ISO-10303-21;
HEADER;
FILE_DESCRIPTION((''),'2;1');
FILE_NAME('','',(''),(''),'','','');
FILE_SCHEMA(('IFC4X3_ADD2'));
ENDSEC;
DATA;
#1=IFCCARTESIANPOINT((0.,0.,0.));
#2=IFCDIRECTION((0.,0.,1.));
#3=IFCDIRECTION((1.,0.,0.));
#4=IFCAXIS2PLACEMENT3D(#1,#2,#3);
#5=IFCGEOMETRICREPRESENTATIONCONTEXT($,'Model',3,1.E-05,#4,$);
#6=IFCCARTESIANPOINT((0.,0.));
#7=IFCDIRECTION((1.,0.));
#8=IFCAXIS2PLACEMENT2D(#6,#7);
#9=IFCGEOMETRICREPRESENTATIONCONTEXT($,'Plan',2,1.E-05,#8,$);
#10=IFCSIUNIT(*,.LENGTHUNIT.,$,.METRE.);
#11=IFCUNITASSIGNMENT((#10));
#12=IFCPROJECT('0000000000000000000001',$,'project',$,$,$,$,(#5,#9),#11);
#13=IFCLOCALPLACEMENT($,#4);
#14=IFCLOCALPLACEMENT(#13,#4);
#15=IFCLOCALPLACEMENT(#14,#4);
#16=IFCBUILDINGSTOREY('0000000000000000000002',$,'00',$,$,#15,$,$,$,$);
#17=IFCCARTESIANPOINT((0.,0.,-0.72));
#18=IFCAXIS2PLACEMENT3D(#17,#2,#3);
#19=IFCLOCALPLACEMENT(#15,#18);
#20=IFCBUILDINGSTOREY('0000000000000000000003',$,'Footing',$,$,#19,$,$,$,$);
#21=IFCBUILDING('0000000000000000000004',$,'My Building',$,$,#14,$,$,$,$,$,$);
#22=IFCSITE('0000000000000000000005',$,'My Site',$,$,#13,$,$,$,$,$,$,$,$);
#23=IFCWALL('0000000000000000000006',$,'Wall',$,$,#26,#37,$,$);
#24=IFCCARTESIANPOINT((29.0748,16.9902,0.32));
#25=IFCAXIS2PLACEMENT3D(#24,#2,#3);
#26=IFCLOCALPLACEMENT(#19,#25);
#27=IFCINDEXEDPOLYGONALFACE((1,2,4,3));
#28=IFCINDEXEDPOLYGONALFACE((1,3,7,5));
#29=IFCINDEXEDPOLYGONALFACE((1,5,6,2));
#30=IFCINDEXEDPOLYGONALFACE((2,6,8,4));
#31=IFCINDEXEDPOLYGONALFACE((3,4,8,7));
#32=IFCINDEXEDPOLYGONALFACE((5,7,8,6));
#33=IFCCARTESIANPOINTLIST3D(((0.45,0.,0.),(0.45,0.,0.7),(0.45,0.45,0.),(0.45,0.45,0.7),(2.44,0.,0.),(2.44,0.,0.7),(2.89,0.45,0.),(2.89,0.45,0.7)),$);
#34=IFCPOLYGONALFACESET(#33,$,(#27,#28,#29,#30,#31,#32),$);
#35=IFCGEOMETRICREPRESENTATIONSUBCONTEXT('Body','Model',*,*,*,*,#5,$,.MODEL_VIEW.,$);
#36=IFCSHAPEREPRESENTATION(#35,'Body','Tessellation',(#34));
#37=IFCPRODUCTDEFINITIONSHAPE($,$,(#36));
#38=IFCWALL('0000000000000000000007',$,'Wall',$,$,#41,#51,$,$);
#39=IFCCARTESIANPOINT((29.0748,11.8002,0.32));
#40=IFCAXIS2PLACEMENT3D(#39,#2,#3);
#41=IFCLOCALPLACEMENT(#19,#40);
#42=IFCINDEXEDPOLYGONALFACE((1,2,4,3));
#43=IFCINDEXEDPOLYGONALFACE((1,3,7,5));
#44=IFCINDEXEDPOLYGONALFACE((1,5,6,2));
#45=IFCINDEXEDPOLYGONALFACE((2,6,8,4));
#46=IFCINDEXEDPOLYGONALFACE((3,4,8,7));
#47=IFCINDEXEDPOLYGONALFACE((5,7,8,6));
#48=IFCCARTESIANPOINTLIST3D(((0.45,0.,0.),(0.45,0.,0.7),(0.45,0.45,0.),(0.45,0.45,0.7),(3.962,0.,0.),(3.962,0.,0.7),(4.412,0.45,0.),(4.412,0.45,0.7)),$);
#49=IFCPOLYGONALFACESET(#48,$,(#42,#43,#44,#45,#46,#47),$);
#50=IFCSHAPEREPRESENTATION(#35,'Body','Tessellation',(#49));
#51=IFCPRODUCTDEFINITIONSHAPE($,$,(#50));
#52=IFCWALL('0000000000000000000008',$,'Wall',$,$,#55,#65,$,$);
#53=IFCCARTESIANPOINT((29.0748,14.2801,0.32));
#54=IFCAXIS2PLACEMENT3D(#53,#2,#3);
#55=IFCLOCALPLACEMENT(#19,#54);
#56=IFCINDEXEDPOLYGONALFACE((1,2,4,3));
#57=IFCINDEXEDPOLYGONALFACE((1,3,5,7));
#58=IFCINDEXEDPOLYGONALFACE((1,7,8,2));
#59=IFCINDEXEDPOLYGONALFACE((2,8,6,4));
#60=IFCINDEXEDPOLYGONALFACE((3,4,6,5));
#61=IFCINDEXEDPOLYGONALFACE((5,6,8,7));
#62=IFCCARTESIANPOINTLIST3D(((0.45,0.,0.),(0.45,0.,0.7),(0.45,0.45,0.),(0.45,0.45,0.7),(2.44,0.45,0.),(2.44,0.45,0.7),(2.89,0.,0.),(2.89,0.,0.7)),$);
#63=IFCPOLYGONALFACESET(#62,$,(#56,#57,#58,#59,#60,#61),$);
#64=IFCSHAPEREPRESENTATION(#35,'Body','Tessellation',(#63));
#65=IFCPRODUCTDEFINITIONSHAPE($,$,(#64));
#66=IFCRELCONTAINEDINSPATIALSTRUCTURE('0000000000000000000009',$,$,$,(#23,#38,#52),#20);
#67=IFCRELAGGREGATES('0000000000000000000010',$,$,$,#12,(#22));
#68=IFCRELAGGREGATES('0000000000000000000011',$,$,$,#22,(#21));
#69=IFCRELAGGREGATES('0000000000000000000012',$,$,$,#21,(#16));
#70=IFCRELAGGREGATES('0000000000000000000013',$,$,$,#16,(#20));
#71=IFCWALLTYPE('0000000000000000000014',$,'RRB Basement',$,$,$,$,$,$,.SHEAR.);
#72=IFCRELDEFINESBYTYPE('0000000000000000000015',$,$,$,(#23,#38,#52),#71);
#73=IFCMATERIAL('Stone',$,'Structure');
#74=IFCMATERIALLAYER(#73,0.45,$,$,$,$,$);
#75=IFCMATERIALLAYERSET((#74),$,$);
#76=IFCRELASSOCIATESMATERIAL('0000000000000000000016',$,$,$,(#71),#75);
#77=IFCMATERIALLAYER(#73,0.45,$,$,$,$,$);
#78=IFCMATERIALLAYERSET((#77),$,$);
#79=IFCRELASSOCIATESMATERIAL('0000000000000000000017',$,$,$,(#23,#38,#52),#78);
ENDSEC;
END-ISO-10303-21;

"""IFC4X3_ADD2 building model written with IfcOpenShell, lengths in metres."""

from ifc_helpers import new_model, si_unit, frame, origin_with_axes, origin_2d_with_axis, place, context, subcontext, project, spatial, line, indexed_curve, outline, extrude, material, layer, layer_set, layer_usage, type_object, element, save


model = new_model("IFC4X3_ADD2")

# Units and contexts
model_context = context("Model", 3, precision=1e-05, world=origin_with_axes())
plan_context = context("Plan", 2, precision=1e-05, world=origin_2d_with_axis())
body_context = subcontext(model_context, "Body", "Model", "MODEL_VIEW")
ifc_project = project(units=[si_unit("LENGTHUNIT", "METRE")], contexts=[model_context, plan_context])

# Site, building, storeys
site_placement = place(None, origin_with_axes())
site = spatial("IfcSite", under=ifc_project, at=site_placement, Name="My Site")
building_placement = place(site_placement, origin_with_axes())
building = spatial("IfcBuilding", under=site, at=building_placement, Name="My Building")
storey_1_placement = place(building_placement, origin_with_axes())
storey_1 = spatial("IfcBuildingStorey", under=building, at=storey_1_placement, Name="00")
storey_2_placement = place(storey_1_placement, frame((0.0, 0.0, -0.72), z_axis=(0.0, 0.0, 1.0), x_axis=(1.0, 0.0, 0.0)))
storey_2 = spatial("IfcBuildingStorey", under=storey_1, at=storey_2_placement, Name="Footing")

# Walls
ifc_material_1 = material(Name="Stone", Category="Structure")
ifc_layer_1 = layer(ifc_material_1, 0.45)
ifc_layer_set_1 = layer_set([ifc_layer_1])
wall_type_1 = type_object("IfcWallType", Name="RRB Basement", PredefinedType="SHEAR", material=ifc_layer_set_1)
ifc_layer_2 = layer(ifc_material_1, 0.45)
ifc_layer_set_2 = layer_set([ifc_layer_2])
ifc_layer_usage_1 = layer_usage(ifc_layer_set_2, "AXIS2", "POSITIVE", 0.0)
wall_1_placement = place(storey_2_placement, frame((29.0748, 16.9902, 0.32), z_axis=(0.0, 0.0, 1.0), x_axis=(1.0, 0.0, 0.0)))
element("IfcWall", 1, at=wall_1_placement, inside=storey_2, type_object=wall_type_1, material=ifc_layer_usage_1, Name="Wall", context=body_context, shape_type="SweptSolid", body=[
    extrude(outline(indexed_curve([(0.45, 0.0), (0.45, 0.45), (2.89, 0.45), (2.44, 0.0)], segments=[line(1, 2, 3, 4, 1)])), origin_with_axes(), (0.0, 0.0, 1.0), 0.7),
])
ifc_layer_usage_2 = layer_usage(ifc_layer_set_2, "AXIS2", "POSITIVE", 0.0)
wall_2_placement = place(storey_2_placement, frame((29.0748, 11.8002, 0.32), z_axis=(0.0, 0.0, 1.0), x_axis=(1.0, 0.0, 0.0)))
element("IfcWall", 2, at=wall_2_placement, inside=storey_2, type_object=wall_type_1, material=ifc_layer_usage_2, Name="Wall", context=body_context, shape_type="SweptSolid", body=[
    extrude(outline(indexed_curve([(0.45, 0.0), (0.45, 0.45), (4.412, 0.45), (3.962, 0.0)], segments=[line(1, 2, 3, 4, 1)])), origin_with_axes(), (0.0, 0.0, 1.0), 0.7),
])
ifc_layer_usage_3 = layer_usage(ifc_layer_set_2, "AXIS2", "POSITIVE", 0.0)
wall_3_placement = place(storey_2_placement, frame((29.0748, 14.2801, 0.32), z_axis=(0.0, 0.0, 1.0), x_axis=(1.0, 0.0, 0.0)))
element("IfcWall", 3, at=wall_3_placement, inside=storey_2, type_object=wall_type_1, material=ifc_layer_usage_3, Name="Wall", context=body_context, shape_type="SweptSolid", body=[
    extrude(outline(indexed_curve([(0.45, 0.0), (0.45, 0.45), (2.44, 0.45), (2.89, 0.0)], segments=[line(1, 2, 3, 4, 1)])), origin_with_axes(), (0.0, 0.0, 1.0), 0.7),
])

save(model, "model.ifc")
